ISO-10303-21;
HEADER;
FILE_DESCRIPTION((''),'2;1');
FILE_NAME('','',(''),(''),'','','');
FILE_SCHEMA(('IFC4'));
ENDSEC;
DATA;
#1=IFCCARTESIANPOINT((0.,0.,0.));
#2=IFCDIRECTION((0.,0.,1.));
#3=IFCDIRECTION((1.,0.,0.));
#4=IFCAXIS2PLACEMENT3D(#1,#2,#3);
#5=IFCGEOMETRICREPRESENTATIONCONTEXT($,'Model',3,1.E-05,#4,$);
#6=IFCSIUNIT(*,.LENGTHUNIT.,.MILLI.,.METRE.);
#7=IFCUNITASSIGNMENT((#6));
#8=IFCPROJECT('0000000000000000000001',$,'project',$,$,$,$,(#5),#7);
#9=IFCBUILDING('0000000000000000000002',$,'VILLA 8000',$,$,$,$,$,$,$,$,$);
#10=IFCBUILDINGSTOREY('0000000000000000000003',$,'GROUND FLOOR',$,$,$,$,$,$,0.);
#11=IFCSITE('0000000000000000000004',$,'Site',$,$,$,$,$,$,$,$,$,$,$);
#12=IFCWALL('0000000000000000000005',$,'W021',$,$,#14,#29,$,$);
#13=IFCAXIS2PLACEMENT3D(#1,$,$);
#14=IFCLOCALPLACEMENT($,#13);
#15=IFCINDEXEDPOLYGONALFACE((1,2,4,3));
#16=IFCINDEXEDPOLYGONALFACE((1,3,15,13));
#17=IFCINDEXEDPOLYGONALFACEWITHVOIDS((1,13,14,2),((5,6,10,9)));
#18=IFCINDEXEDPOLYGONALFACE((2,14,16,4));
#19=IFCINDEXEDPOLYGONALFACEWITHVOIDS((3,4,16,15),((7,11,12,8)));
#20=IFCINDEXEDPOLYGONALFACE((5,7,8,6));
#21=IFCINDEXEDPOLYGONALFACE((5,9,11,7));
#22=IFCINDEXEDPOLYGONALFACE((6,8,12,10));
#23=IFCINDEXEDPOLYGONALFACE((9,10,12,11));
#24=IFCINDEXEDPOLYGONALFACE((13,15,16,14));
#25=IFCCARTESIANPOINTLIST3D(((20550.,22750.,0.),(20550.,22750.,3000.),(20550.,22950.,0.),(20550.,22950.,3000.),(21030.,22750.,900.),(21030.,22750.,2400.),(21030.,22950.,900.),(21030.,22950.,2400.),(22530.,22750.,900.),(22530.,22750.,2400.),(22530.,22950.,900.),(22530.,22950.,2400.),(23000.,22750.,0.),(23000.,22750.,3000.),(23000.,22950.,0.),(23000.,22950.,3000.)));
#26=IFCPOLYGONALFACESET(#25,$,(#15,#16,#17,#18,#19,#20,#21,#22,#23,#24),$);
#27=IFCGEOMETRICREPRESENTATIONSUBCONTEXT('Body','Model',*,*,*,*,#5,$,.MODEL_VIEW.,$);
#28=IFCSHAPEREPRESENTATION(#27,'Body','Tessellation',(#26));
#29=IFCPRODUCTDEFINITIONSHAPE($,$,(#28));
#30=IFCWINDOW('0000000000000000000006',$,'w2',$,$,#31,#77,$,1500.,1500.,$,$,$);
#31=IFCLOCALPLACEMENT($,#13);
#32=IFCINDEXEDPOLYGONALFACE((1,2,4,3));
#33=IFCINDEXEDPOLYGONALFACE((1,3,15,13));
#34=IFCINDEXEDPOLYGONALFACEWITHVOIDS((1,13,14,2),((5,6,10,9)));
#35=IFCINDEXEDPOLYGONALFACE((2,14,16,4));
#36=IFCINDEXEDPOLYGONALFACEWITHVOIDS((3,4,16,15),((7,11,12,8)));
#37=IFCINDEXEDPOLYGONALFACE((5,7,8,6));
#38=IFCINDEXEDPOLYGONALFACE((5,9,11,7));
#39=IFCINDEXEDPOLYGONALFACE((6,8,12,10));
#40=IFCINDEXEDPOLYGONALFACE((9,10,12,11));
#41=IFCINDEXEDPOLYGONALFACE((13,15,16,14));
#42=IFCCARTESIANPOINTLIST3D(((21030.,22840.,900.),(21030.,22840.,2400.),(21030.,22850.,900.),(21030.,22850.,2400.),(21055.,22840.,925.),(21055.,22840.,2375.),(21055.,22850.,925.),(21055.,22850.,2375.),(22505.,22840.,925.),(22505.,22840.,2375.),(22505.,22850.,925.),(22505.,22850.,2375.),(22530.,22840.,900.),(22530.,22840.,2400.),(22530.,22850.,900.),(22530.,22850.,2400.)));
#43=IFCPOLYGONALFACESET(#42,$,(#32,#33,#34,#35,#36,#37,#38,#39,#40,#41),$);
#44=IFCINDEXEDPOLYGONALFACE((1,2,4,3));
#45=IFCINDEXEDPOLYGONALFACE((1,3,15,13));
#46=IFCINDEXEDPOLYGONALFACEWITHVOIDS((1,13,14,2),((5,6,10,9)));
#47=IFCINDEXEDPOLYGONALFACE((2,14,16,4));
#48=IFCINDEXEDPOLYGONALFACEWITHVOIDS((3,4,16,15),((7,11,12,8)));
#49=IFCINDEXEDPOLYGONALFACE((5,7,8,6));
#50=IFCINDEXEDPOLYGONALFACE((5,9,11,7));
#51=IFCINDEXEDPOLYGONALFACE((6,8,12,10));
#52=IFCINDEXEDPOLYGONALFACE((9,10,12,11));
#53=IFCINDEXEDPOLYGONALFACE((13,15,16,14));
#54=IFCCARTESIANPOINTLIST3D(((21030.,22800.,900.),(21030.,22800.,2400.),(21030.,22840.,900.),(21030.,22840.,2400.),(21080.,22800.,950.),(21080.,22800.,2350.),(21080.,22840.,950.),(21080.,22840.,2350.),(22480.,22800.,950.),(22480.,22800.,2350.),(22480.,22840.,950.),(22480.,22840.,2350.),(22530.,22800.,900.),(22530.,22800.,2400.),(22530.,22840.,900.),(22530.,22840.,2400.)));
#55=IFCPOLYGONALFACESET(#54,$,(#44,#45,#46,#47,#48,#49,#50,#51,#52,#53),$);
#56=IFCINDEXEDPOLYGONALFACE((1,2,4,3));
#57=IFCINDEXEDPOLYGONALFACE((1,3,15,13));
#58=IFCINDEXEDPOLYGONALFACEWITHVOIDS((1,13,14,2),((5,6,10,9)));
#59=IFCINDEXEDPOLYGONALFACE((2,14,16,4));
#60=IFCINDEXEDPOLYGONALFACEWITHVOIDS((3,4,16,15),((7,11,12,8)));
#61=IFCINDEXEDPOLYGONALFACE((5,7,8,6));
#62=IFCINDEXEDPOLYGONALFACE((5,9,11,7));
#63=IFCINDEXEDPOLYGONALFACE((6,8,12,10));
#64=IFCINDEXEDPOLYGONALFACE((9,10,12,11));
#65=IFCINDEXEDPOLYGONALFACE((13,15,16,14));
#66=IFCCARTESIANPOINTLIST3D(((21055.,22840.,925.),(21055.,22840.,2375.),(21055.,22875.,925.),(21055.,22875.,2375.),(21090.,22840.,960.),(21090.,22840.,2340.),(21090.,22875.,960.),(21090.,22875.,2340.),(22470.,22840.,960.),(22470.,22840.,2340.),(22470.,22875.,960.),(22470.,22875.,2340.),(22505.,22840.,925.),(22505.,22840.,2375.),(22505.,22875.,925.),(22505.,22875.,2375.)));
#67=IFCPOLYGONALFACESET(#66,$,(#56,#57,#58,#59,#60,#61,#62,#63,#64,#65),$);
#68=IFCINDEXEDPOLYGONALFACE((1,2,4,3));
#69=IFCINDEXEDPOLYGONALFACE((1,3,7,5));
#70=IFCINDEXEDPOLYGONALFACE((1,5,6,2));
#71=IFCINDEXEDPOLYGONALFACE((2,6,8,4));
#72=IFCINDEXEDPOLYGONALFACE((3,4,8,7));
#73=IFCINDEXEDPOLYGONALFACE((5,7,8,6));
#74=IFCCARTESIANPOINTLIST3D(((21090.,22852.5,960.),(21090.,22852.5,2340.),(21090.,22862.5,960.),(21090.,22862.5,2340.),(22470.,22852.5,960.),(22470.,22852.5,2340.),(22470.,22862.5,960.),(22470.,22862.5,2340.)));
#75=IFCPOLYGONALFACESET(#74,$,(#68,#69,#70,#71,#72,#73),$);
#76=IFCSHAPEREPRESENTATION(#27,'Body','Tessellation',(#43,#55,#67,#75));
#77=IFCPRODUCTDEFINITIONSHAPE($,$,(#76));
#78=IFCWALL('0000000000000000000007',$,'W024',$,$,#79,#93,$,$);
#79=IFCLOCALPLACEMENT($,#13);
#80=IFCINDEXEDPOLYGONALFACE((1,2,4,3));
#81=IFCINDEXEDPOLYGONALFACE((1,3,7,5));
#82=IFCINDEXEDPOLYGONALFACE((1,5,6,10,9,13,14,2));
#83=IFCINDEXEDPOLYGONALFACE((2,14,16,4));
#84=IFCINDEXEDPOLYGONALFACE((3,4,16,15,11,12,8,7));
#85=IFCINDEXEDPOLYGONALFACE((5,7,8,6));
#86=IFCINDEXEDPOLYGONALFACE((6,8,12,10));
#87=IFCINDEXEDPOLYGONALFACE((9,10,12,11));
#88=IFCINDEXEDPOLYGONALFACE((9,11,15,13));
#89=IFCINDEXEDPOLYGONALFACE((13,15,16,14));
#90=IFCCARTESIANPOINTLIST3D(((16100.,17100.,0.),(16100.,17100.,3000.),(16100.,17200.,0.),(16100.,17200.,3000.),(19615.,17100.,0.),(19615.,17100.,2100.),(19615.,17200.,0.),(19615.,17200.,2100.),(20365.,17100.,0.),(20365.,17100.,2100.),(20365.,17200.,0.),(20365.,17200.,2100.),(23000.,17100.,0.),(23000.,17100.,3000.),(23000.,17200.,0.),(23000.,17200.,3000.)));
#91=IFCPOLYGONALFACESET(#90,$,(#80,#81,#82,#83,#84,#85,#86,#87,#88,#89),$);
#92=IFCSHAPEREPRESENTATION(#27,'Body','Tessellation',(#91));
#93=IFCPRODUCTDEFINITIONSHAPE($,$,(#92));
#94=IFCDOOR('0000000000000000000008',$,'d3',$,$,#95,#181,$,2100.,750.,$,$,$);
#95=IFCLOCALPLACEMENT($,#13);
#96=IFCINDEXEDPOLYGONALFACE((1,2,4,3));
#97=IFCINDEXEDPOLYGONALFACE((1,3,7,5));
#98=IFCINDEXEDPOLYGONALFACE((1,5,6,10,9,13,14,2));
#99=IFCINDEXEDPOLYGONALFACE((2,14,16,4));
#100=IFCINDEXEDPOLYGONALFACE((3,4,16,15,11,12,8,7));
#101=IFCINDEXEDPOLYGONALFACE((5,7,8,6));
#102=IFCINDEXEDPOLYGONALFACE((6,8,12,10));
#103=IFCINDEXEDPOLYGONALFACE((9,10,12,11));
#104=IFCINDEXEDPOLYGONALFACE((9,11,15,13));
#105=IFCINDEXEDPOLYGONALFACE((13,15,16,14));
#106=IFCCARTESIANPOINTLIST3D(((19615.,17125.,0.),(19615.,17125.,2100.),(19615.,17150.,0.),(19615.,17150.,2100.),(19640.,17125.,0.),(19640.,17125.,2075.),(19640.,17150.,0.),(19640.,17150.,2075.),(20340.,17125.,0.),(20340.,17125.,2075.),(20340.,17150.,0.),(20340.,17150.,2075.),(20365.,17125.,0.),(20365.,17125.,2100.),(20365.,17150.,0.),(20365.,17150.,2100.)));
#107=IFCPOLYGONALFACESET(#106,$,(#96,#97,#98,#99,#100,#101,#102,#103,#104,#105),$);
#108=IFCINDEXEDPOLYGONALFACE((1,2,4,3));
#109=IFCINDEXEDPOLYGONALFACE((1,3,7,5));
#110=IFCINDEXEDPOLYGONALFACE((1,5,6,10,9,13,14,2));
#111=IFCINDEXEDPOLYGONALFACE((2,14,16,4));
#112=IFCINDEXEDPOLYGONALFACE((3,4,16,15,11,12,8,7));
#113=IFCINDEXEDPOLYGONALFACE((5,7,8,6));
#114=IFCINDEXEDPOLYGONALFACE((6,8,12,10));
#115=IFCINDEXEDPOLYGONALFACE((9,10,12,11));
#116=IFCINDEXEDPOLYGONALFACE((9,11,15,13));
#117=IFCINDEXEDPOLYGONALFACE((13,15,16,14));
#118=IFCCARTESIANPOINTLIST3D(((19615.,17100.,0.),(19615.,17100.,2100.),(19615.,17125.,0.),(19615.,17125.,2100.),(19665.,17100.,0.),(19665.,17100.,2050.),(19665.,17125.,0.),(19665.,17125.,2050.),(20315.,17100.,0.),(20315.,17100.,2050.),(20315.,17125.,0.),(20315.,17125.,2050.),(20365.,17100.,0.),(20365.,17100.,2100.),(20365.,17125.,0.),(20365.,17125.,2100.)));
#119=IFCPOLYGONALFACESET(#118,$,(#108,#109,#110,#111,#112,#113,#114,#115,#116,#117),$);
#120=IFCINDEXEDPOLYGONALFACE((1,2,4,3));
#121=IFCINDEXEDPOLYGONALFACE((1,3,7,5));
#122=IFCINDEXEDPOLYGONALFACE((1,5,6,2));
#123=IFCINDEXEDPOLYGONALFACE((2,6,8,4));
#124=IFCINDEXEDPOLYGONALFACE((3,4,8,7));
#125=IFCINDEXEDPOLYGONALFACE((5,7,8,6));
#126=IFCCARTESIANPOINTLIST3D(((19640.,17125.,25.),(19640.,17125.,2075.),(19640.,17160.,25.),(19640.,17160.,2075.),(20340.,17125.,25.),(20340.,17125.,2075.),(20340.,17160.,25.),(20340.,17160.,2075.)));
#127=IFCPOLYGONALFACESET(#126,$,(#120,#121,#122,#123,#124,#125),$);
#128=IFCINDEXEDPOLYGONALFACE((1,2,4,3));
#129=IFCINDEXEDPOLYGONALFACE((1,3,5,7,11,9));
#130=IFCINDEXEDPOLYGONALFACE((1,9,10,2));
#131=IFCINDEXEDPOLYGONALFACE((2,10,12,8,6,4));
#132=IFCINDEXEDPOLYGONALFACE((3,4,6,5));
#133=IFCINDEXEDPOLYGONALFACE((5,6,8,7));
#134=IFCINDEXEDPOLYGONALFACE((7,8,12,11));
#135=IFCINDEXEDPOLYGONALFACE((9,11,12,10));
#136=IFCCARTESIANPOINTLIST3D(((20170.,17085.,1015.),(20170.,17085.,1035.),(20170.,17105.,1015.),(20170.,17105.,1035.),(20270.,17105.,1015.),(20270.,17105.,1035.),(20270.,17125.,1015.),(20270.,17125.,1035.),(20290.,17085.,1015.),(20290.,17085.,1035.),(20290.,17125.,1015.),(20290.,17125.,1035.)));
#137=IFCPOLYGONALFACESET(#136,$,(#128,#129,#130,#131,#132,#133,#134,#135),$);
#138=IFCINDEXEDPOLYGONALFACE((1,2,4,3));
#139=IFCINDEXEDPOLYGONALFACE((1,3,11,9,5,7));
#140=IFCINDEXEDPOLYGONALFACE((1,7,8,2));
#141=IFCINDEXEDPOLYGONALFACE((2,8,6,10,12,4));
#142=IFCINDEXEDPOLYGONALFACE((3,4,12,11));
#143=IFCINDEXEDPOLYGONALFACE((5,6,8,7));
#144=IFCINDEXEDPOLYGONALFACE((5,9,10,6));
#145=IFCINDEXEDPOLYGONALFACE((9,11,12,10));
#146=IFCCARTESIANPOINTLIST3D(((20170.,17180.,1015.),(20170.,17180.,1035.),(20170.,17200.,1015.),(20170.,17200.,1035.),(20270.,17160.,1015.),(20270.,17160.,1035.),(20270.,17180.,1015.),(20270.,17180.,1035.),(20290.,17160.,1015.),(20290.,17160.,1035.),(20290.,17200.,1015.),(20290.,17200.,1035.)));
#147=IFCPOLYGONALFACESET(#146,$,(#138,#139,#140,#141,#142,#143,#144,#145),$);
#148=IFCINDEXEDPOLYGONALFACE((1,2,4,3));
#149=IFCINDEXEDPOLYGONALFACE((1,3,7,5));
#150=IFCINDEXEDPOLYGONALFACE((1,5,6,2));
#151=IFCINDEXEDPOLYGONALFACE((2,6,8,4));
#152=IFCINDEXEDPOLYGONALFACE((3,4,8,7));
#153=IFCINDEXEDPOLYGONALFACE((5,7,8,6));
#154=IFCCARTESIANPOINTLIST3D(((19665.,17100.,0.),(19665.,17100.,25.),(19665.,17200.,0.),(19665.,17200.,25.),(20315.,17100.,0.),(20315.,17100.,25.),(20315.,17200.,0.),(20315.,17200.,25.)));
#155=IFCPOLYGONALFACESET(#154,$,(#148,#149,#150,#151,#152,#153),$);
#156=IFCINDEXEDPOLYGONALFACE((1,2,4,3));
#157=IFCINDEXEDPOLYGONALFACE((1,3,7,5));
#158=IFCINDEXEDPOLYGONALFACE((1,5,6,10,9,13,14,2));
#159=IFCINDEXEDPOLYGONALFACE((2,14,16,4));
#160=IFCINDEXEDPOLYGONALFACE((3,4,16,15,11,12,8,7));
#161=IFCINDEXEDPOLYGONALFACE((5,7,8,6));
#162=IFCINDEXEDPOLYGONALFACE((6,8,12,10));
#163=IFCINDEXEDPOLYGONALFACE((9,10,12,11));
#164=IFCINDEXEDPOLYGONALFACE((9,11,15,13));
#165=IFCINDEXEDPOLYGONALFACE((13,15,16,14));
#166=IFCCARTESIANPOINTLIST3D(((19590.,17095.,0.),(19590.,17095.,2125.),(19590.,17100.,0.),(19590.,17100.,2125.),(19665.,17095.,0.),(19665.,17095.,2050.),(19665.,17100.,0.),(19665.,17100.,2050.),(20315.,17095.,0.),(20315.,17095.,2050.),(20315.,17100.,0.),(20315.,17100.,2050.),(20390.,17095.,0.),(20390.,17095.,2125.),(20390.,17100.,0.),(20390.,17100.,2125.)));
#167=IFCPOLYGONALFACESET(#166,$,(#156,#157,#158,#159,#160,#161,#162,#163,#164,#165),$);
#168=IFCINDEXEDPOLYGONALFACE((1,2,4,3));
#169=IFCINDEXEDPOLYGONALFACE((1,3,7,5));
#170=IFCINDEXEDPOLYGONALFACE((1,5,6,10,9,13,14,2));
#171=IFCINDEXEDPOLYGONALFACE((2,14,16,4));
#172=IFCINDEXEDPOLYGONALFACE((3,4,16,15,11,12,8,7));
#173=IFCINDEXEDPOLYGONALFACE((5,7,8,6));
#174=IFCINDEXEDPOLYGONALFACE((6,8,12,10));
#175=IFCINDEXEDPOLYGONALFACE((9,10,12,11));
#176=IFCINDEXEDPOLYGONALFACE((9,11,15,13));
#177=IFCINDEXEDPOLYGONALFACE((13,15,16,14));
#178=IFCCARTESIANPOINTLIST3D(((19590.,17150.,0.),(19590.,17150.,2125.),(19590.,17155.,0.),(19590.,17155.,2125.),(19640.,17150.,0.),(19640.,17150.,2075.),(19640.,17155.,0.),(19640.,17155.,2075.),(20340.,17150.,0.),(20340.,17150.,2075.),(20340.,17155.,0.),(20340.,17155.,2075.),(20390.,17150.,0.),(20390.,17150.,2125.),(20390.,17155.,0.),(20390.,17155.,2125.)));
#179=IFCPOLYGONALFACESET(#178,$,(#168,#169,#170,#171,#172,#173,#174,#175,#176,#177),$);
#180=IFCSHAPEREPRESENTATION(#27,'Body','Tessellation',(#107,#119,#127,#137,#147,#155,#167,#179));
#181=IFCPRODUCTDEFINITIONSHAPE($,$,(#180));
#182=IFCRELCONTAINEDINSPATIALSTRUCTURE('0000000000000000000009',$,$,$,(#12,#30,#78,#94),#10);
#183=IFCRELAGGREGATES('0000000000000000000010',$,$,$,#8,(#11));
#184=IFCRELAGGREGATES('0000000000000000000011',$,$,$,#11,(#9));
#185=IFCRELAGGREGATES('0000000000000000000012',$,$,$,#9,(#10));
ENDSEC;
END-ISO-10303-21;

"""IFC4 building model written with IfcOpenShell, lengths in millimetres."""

from ifc_helpers import new_model, si_unit, frame, origin_with_axes, place, context, subcontext, project, spatial, line, indexed_curve, outline, extrude, element, fill, save


model = new_model("IFC4")

# Units and contexts
model_context = context("Model", 3, precision=1e-05, world=origin_with_axes())
body_context = subcontext(model_context, "Body", "Model", "MODEL_VIEW")
ifc_project = project(units=[si_unit("LENGTHUNIT", "METRE", prefix="MILLI")], contexts=[model_context])

# Site, building, storey
site = spatial("IfcSite", under=ifc_project, Name="Site")
building = spatial("IfcBuilding", under=site, Name="VILLA 8000")
storey = spatial("IfcBuildingStorey", under=building, Name="GROUND FLOOR", Elevation=0.0)

# Wall, opening, window
wall_1_placement = place(None, frame((20550.0, 22850.0, 0.0), z_axis=(0.0, 0.0, 1.0), x_axis=(1.0, 0.0, 0.0)))
wall_1 = element("IfcWall", 1, at=wall_1_placement, inside=storey, Name="W021", context=body_context, shape_type="SweptSolid", body=[
    extrude(outline(indexed_curve([(0.0, 0.0), (0.0, 200.0), (2450.0, 200.0), (2450.0, 0.0), (0.0, 0.0)], self_intersect=False)), frame((0.0, -100.0, 0.0), z_axis=(0.0, 0.0, 1.0), x_axis=(1.0, 0.0, 0.0)), (0.0, 0.0, 1.0), 3000.0),
])
opening_1_placement = place(wall_1_placement, frame((480.0, 0.0, 900.0), z_axis=(0.0, 0.0, 1.0), x_axis=(1.0, 0.0, 0.0)))
opening_1 = element("IfcOpeningElement", 2, at=opening_1_placement, cuts=wall_1, context=body_context, shape_type="SweptSolid", body=[
    extrude(outline(indexed_curve([(0.0, 0.0), (0.0, 300.0), (1500.0, 300.0), (1500.0, 0.0), (0.0, 0.0)], self_intersect=False)), frame((0.0, -150.0, 0.0), z_axis=(0.0, 0.0, 1.0), x_axis=(1.0, 0.0, 0.0)), (0.0, 0.0, 1.0), 1500.0),
])
window_1_placement = place(None, frame((21030.0, 22750.0, 900.0), z_axis=(0.0, 0.0, 1.0), x_axis=(1.0, 0.0, 0.0)))
window_1 = element("IfcWindow", 3, at=window_1_placement, inside=storey, Name="w2", OverallHeight=1500.0, OverallWidth=1500.0, context=body_context, shape_type="SweptSolid", body=[
    extrude(outline(indexed_curve([(0.0, 0.0), (1500.0, 0.0), (1500.0, 1500.0), (0.0, 1500.0)], segments=[line(1, 2, 3, 4, 1)]), holes=[indexed_curve([(25.0, 25.0), (1475.0, 25.0), (1475.0, 1475.0), (25.0, 1475.0)], segments=[line(1, 2, 3, 4, 1)])]), frame((0.0, 90.0, 0.0), z_axis=(0.0, -1.0, 0.0), x_axis=(1.0, 0.0, 0.0)), (0.0, 0.0, -1.0), 10.0),
    extrude(outline(indexed_curve([(0.0, 0.0), (1500.0, 0.0), (1500.0, 1500.0), (0.0, 1500.0)], segments=[line(1, 2, 3, 4, 1)]), holes=[indexed_curve([(50.0, 50.0), (1450.0, 50.0), (1450.0, 1450.0), (50.0, 1450.0)], segments=[line(1, 2, 3, 4, 1)])]), frame((0.0, 50.0, 0.0), z_axis=(0.0, -1.0, 0.0), x_axis=(1.0, 0.0, 0.0)), (0.0, 0.0, -1.0), 40.0),
    extrude(outline(indexed_curve([(0.0, 0.0), (1450.0, 0.0), (1450.0, 1450.0), (0.0, 1450.0)], segments=[line(1, 2, 3, 4, 1)]), holes=[indexed_curve([(35.0, 35.0), (1415.0, 35.0), (1415.0, 1415.0), (35.0, 1415.0)], segments=[line(1, 2, 3, 4, 1)])]), frame((25.0, 90.0, 25.0), z_axis=(0.0, -1.0, 0.0), x_axis=(1.0, 0.0, 0.0)), (0.0, 0.0, -1.0), 35.0),
    extrude(outline(indexed_curve([(35.0, 35.0), (1415.0, 35.0), (1415.0, 1415.0), (35.0, 1415.0)], segments=[line(1, 2, 3, 4, 1)])), frame((25.0, 102.5, 25.0), z_axis=(0.0, -1.0, 0.0), x_axis=(1.0, 0.0, 0.0)), (0.0, 0.0, -1.0), 10.0),
])
fill(opening_1, window_1)

# Wall, opening, door
wall_2_placement = place(None, frame((16100.0, 17150.0, 0.0), z_axis=(0.0, 0.0, 1.0), x_axis=(1.0, 0.0, 0.0)))
wall_2 = element("IfcWall", 4, at=wall_2_placement, inside=storey, Name="W024", context=body_context, shape_type="SweptSolid", body=[
    extrude(outline(indexed_curve([(0.0, 0.0), (0.0, 100.0), (6900.0, 100.0), (6900.0, 0.0), (0.0, 0.0)], self_intersect=False)), frame((0.0, -50.0, 0.0), z_axis=(0.0, 0.0, 1.0), x_axis=(1.0, 0.0, 0.0)), (0.0, 0.0, 1.0), 3000.0),
])
opening_2_placement = place(wall_2_placement, frame((3515.0, 0.0, 0.0), z_axis=(0.0, 0.0, 1.0), x_axis=(1.0, 0.0, 0.0)))
opening_2 = element("IfcOpeningElement", 5, at=opening_2_placement, cuts=wall_2, context=body_context, shape_type="SweptSolid", body=[
    extrude(outline(indexed_curve([(0.0, 0.0), (0.0, 200.0), (750.0, 200.0), (750.0, 0.0), (0.0, 0.0)], self_intersect=False)), frame((0.0, -100.0, 0.0), z_axis=(0.0, 0.0, 1.0), x_axis=(1.0, 0.0, 0.0)), (0.0, 0.0, 1.0), 2100.0),
])
door_1_placement = place(None, frame((19615.0, 17100.0, 0.0), z_axis=(0.0, 0.0, 1.0), x_axis=(1.0, 0.0, 0.0)))
door_1 = element("IfcDoor", 6, at=door_1_placement, inside=storey, Name="d3", OverallHeight=2100.0, OverallWidth=750.0, context=body_context, shape_type="SweptSolid", body=[
    extrude(outline(indexed_curve([(0.0, 0.0), (0.0, 2100.0), (750.0, 2100.0), (750.0, 0.0), (725.0, 0.0), (725.0, 2075.0), (25.0, 2075.0), (25.0, 0.0)], segments=[line(1, 2, 3, 4, 5, 6, 7, 8, 1)])), frame((0.0, 25.0, 0.0), z_axis=(0.0, -1.0, 0.0), x_axis=(1.0, 0.0, 0.0)), (0.0, 0.0, -1.0), 25.0),
    extrude(outline(indexed_curve([(0.0, 0.0), (0.0, 2100.0), (750.0, 2100.0), (750.0, 0.0), (700.0, 0.0), (700.0, 2050.0), (50.0, 2050.0), (50.0, 0.0)], segments=[line(1, 2, 3, 4, 5, 6, 7, 8, 1)])), frame((0.0, 0.0, 0.0), z_axis=(0.0, -1.0, 0.0), x_axis=(1.0, 0.0, 0.0)), (0.0, 0.0, -1.0), 25.0),
    extrude(outline(indexed_curve([(0.0, 0.0), (700.0, 0.0), (700.0, 35.0), (0.0, 35.0)], segments=[line(1, 2, 3, 4, 1)])), frame((25.0, 25.0, 25.0), z_axis=(0.0, 0.0, 1.0), x_axis=(1.0, 0.0, 0.0)), (0.0, 0.0, 1.0), 2050.0),
    extrude(outline(indexed_curve([(0.0, 0.0), (0.0, -40.0), (-120.0, -40.0), (-120.0, -20.0), (-20.0, -20.0), (-20.0, 0.0)], segments=[line(1, 2, 3, 4, 5, 6, 1)])), frame((675.0, 25.0, 1015.0), z_axis=(0.0, 0.0, 1.0), x_axis=(1.0, 0.0, 0.0)), (0.0, 0.0, 1.0), 20.0),
    extrude(outline(indexed_curve([(0.0, 0.0), (0.0, 40.0), (-120.0, 40.0), (-120.0, 20.0), (-20.0, 20.0), (-20.0, 0.0)], segments=[line(1, 2, 3, 4, 5, 6, 1)])), frame((675.0, 60.0, 1015.0), z_axis=(0.0, 0.0, 1.0), x_axis=(1.0, 0.0, 0.0)), (0.0, 0.0, 1.0), 20.0),
    extrude(outline(indexed_curve([(0.0, 0.0), (650.0, 0.0), (650.0, 100.0), (0.0, 100.0)], segments=[line(1, 2, 3, 4, 1)])), frame((50.0, 0.0, 0.0), z_axis=(0.0, 0.0, 1.0), x_axis=(1.0, 0.0, 0.0)), (0.0, 0.0, 1.0), 25.0),
    extrude(outline(indexed_curve([(0.0, 0.0), (0.0, 2125.0), (800.0, 2125.0), (800.0, 0.0), (725.0, 0.0), (725.0, 2050.0), (75.0, 2050.0), (75.0, 0.0)], segments=[line(1, 2, 3, 4, 5, 6, 7, 8, 1)])), frame((-25.0, -5.0, 0.0), z_axis=(0.0, -1.0, 0.0), x_axis=(1.0, 0.0, 0.0)), (0.0, 0.0, -1.0), 5.0),
    extrude(outline(indexed_curve([(0.0, 0.0), (0.0, 2125.0), (800.0, 2125.0), (800.0, 0.0), (750.0, 0.0), (750.0, 2075.0), (50.0, 2075.0), (50.0, 0.0)], segments=[line(1, 2, 3, 4, 5, 6, 7, 8, 1)])), frame((-25.0, 50.0, 0.0), z_axis=(0.0, -1.0, 0.0), x_axis=(1.0, 0.0, 0.0)), (0.0, 0.0, -1.0), 5.0),
])
fill(opening_2, door_1)

save(model, "model.ifc")
